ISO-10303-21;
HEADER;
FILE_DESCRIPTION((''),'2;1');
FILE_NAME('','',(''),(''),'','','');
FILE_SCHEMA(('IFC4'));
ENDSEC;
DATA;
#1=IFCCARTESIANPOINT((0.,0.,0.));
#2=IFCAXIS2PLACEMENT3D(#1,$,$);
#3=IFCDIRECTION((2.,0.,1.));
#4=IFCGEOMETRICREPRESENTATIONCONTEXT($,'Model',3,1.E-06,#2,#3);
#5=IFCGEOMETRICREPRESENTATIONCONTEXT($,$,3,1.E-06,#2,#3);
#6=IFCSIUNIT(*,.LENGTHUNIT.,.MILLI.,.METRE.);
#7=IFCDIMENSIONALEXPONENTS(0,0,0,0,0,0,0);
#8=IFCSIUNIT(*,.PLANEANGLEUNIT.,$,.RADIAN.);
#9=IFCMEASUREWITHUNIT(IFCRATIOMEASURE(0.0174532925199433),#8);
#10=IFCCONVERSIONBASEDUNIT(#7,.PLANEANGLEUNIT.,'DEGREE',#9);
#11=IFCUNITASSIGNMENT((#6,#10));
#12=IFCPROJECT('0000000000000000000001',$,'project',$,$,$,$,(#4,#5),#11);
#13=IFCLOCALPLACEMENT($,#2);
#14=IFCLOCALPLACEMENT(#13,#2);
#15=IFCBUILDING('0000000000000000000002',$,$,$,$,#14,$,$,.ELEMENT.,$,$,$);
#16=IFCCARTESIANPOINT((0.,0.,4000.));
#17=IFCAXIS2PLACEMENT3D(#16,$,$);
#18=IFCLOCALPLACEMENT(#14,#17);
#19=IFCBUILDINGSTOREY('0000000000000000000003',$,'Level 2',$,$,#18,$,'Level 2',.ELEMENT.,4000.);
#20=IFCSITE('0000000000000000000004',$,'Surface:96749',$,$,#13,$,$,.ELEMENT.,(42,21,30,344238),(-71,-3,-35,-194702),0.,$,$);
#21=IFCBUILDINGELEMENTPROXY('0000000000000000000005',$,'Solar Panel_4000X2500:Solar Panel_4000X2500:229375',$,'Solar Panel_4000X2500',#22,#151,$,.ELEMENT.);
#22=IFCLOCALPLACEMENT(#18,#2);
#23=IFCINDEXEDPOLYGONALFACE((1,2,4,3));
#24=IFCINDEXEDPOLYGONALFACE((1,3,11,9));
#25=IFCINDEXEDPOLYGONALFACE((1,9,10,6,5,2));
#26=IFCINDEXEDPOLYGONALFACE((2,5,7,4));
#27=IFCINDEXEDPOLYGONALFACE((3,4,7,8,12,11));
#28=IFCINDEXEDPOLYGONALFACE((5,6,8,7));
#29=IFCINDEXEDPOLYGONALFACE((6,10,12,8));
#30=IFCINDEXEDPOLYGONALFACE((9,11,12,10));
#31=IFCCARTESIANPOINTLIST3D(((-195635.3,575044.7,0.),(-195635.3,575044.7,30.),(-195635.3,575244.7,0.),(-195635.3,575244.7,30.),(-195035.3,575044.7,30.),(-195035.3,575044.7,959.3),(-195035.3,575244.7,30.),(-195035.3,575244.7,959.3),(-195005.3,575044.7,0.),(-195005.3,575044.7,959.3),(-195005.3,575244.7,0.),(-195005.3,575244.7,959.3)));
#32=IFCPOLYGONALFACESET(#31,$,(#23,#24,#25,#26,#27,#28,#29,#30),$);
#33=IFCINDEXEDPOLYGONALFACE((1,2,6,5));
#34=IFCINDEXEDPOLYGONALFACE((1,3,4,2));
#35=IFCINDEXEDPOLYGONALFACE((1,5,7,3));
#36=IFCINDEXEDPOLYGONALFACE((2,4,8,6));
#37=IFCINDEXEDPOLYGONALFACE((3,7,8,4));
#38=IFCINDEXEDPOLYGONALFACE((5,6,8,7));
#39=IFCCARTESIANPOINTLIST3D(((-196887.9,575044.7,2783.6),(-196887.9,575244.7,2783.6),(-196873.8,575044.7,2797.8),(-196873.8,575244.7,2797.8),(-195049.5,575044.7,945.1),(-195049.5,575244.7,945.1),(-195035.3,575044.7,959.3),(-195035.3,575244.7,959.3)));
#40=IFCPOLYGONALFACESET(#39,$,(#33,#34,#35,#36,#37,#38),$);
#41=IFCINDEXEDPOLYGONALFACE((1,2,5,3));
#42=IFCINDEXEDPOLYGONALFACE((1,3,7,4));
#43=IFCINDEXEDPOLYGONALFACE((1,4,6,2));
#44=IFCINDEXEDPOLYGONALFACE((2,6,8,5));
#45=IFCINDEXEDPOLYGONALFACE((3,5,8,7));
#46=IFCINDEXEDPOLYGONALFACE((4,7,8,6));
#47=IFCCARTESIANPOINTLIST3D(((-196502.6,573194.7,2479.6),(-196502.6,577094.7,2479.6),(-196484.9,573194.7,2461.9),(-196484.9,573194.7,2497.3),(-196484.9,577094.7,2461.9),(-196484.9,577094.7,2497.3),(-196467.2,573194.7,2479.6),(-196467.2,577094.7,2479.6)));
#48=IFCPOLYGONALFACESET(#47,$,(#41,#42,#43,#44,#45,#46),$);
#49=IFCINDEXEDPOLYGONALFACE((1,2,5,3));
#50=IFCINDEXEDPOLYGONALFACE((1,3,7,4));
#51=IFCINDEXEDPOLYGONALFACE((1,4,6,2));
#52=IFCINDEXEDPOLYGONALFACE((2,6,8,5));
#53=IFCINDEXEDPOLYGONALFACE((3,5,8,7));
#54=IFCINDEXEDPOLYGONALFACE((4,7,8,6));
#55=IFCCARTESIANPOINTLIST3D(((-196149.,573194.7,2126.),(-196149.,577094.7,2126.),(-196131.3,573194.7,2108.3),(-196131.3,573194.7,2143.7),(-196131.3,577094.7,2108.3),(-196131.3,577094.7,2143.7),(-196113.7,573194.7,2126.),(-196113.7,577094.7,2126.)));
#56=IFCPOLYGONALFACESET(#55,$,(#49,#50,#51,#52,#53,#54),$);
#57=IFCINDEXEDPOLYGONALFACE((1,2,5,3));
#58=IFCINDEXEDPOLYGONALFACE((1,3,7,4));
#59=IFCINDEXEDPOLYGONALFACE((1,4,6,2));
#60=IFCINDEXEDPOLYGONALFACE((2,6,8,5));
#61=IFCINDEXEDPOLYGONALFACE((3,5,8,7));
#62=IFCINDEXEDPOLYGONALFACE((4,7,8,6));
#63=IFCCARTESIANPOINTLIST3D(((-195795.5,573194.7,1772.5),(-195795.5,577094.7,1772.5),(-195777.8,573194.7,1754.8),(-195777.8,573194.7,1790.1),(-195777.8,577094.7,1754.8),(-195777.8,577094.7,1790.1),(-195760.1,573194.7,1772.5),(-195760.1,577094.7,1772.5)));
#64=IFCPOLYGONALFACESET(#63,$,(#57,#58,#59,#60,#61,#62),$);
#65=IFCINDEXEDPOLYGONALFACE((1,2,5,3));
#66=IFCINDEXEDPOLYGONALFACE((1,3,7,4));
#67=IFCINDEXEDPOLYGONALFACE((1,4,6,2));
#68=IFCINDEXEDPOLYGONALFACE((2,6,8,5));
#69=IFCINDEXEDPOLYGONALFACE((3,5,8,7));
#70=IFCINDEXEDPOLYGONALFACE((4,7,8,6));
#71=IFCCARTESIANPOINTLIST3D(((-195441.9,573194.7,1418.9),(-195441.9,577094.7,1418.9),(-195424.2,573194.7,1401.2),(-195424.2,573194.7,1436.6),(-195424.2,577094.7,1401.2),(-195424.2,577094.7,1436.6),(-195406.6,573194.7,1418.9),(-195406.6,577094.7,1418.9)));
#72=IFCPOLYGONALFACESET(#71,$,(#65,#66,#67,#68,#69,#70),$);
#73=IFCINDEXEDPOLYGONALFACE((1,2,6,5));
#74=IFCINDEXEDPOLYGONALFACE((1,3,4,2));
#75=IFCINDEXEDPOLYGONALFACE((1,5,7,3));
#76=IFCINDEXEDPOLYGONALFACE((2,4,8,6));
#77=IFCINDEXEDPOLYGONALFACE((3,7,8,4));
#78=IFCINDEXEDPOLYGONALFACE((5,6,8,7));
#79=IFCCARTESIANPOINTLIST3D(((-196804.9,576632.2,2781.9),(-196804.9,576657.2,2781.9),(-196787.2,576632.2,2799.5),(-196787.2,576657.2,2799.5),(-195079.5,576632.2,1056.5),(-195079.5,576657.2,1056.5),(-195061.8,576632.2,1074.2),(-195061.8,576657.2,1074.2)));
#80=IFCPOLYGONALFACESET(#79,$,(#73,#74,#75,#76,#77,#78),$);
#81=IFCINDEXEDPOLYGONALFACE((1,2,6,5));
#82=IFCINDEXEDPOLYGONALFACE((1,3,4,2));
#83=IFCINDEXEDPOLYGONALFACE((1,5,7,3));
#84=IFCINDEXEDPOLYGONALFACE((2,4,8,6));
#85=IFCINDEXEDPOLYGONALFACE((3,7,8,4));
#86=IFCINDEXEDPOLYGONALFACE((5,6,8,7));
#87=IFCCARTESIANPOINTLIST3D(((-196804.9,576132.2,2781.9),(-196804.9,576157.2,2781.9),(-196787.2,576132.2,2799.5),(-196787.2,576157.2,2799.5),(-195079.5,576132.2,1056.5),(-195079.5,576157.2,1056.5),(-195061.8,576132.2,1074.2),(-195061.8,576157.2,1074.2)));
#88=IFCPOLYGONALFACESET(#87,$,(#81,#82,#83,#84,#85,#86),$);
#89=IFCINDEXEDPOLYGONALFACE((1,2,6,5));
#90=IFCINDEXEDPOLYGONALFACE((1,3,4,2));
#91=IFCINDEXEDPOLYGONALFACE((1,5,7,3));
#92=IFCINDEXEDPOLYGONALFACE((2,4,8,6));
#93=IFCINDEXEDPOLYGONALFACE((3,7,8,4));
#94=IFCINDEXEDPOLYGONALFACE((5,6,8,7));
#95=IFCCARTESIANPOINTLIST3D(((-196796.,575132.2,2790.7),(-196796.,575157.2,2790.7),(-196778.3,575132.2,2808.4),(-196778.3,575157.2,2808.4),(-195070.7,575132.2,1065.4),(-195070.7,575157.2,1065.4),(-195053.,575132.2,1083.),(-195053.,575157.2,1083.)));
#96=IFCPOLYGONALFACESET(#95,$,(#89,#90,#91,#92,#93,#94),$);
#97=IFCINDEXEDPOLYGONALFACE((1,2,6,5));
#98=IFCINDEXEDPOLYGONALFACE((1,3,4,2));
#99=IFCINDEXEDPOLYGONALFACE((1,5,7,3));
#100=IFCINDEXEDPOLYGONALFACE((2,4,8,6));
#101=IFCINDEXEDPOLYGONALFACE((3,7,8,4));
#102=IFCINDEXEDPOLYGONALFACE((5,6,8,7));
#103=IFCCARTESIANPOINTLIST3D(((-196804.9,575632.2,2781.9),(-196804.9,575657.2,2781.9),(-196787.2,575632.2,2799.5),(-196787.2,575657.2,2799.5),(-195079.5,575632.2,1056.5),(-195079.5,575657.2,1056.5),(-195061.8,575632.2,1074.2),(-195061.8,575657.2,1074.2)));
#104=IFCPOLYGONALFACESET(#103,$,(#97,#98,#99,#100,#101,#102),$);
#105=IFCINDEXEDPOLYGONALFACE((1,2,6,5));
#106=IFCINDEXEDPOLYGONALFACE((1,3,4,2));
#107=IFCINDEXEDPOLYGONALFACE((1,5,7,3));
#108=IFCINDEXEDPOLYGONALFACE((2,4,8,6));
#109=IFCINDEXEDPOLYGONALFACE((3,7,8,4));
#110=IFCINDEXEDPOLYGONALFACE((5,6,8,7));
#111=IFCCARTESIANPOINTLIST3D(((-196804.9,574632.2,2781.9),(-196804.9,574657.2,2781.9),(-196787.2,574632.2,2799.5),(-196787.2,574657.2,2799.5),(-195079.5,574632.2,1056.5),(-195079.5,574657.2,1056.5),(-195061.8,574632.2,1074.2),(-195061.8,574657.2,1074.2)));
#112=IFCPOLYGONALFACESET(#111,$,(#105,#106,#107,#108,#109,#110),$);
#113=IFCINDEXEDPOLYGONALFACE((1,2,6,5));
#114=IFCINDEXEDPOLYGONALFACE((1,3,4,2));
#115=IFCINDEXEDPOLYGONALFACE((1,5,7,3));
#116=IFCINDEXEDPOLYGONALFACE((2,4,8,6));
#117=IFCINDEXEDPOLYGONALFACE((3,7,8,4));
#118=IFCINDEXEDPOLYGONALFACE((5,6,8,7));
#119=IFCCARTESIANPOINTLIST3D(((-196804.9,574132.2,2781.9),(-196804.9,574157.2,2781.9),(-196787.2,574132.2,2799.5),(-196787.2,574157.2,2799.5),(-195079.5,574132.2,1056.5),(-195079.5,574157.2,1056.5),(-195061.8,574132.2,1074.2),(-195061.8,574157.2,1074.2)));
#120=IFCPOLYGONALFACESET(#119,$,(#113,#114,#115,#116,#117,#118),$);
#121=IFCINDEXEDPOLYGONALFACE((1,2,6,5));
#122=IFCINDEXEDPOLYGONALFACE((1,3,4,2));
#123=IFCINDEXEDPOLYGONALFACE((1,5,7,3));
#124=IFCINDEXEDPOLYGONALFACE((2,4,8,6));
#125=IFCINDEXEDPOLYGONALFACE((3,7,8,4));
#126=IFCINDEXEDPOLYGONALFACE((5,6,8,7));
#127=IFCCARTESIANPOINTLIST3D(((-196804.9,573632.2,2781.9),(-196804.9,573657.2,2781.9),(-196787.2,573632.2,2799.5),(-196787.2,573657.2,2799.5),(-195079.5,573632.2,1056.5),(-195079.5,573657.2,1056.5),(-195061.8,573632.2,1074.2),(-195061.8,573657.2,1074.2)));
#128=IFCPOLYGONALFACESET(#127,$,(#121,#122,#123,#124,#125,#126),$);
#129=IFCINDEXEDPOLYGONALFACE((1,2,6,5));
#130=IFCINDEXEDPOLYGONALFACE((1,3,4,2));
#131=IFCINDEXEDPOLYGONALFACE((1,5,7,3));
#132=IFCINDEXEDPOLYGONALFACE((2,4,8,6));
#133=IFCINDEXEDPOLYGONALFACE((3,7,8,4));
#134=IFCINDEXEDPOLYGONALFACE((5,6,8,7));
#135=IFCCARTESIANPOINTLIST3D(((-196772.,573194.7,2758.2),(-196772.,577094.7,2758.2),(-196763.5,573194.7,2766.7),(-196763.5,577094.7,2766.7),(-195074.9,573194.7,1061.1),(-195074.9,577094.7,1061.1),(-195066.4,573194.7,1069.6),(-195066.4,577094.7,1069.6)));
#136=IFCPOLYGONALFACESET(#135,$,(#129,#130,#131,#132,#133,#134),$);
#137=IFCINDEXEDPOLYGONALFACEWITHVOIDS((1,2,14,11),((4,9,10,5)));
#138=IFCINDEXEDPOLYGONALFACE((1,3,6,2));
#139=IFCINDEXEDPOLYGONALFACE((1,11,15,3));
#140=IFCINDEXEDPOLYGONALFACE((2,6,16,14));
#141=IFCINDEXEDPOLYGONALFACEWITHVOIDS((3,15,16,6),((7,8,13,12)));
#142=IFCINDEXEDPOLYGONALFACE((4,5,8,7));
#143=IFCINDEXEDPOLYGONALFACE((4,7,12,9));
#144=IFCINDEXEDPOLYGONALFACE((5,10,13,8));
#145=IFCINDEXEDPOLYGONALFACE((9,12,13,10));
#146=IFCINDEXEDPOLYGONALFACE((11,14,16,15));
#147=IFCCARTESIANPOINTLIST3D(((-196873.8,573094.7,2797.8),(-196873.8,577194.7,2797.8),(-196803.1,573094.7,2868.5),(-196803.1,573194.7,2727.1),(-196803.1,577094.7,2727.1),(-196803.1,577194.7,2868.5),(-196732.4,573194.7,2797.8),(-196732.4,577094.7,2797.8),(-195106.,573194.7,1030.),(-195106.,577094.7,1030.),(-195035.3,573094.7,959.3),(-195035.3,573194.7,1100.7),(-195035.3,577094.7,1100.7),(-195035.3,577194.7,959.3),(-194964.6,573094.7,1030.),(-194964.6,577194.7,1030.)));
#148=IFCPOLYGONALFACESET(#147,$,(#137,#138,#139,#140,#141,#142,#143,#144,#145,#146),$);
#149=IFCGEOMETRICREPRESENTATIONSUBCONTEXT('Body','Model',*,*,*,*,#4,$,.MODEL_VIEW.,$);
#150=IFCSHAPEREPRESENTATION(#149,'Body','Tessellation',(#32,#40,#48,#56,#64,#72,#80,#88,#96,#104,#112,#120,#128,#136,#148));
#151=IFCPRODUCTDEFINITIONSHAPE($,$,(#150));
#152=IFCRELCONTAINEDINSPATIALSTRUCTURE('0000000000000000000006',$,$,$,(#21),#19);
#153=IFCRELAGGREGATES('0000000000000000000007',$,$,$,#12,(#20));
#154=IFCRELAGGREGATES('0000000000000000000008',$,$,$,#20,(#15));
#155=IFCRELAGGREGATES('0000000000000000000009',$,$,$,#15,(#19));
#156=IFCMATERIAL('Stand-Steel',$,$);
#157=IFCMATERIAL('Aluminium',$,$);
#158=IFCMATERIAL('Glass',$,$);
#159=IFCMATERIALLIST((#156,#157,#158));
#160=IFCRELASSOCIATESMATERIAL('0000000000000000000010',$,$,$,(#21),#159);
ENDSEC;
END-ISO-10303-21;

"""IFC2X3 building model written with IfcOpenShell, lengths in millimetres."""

from ifc_helpers import new_model, entity, si_unit, converted_unit, direction, frame, frame_2d, origin, origin_2d_with_axis, place, context, subcontext, project, spatial, polyline, rectangle, outline, extrude, source, transform, mapped, material, material_list, element, save


model = new_model("IFC2X3")

# Units and contexts
model_context = context("Model", 3, precision=1e-06, world=origin(), true_north=direction((2.0, 0.0, 1.0)))
context_of_model = context(None, 3, precision=1e-06, world=origin(), true_north=direction((2.0, 0.0, 1.0)))
body_context = subcontext(model_context, "Body", "Model", "MODEL_VIEW")
ifc_project = project(units=[si_unit("LENGTHUNIT", "METRE", prefix="MILLI"), converted_unit("PLANEANGLEUNIT", "DEGREE", entity("IfcRatioMeasure", 0.0174532925199433), si_unit("PLANEANGLEUNIT", "RADIAN"), dimensions=[0, 0, 0, 0, 0, 0, 0])], contexts=[model_context, context_of_model])

# Site, building, storey
site_placement = place(None, origin())
site = spatial("IfcSite", under=ifc_project, at=site_placement, Name="Surface:96749", CompositionType="ELEMENT", RefLatitude=(42, 21, 30, 344238), RefLongitude=(-71, -3, -35, -194702), RefElevation=0.0)
building_placement = place(site_placement, origin())
building = spatial("IfcBuilding", under=site, at=building_placement, CompositionType="ELEMENT")
storey_placement = place(building_placement, frame((0.0, 0.0, 4000.0)))
storey = spatial("IfcBuildingStorey", under=building, at=storey_placement, Name="Level 2", LongName="Level 2", CompositionType="ELEMENT", Elevation=4000.0)

# Building element proxy
ifc_material_1 = material(Name="Stand-Steel")
ifc_material_2 = material(Name="Aluminium")
ifc_material_3 = material(Name="Glass")
shared_shape = source(origin(), body_context, "Body", "SweptSolid", [
    extrude(outline(polyline([(-629.5, -220.0), (329.8, -220.0), (329.8, 410.0), (299.8, 410.0), (299.8, -190.0), (-629.5, -190.0), (-629.5, -220.0)])), frame((-190.0, -100.0, 299.8), z_axis=(0.0, 1.0, 0.0), x_axis=(0.0, 0.0, -1.0)), (0.0, 0.0, 1.0), 200.0),
    extrude(rectangle(XDim=20.0, YDim=200.0, at=frame_2d((0.0, 0.0), x_axis=(0.0, 1.0))), frame((-7.1, 0.0, 922.2), z_axis=(-0.707107, 0.0, 0.707107), x_axis=(0.0, 1.0, 0.0)), (0.0, 0.0, 1.0), 2600.0),
    extrude(rectangle(XDim=25.0, YDim=25.0, at=frame_2d((0.0, 0.0), x_axis=(1.0, 0.0))), frame((-1449.6, -1950.0, 2449.6), z_axis=(0.0, 1.0, 0.0), x_axis=(-0.707107, 0.0, -0.707107)), (0.0, 0.0, 1.0), 3900.0),
    extrude(rectangle(XDim=25.0, YDim=25.0, at=origin_2d_with_axis()), frame((-1096.0, -1950.0, 2096.0), z_axis=(0.0, 1.0, 0.0), x_axis=(-0.707107, 0.0, -0.707107)), (0.0, 0.0, 1.0), 3900.0),
    extrude(rectangle(XDim=25.0, YDim=25.0, at=origin_2d_with_axis()), frame((-742.5, -1950.0, 1742.5), z_axis=(0.0, 1.0, 0.0), x_axis=(-0.707107, 0.0, -0.707107)), (0.0, 0.0, 1.0), 3900.0),
    extrude(rectangle(XDim=25.0, YDim=25.0, at=frame_2d((0.0, 0.0), x_axis=(1.0, 0.0))), frame((-388.9, -1950.0, 1388.9), z_axis=(0.0, 1.0, 0.0), x_axis=(-0.707107, 0.0, -0.707107)), (0.0, 0.0, 1.0), 3900.0),
    extrude(rectangle(XDim=25.0, YDim=25.0, at=frame_2d((0.0, 0.0), x_axis=(0.0, 1.0))), frame((-35.4, 1500.0, 1035.4), z_axis=(-0.707107, 0.0, 0.707107), x_axis=(0.0, 1.0, 0.0)), (0.0, 0.0, 1.0), 2440.0),
    extrude(rectangle(XDim=25.0, YDim=25.0, at=frame_2d((0.0, 0.0), x_axis=(0.0, 1.0))), frame((-35.4, 1000.0, 1035.4), z_axis=(-0.707107, 0.0, 0.707107), x_axis=(0.0, 1.0, 0.0)), (0.0, 0.0, 1.0), 2440.0),
    extrude(rectangle(XDim=25.0, YDim=25.0, at=frame_2d((0.0, 0.0), x_axis=(0.0, 1.0))), frame((-26.5, 0.0, 1044.2), z_axis=(-0.707107, 0.0, 0.707107), x_axis=(0.0, -1.0, 0.0)), (0.0, 0.0, 1.0), 2440.0),
    extrude(rectangle(XDim=25.0, YDim=25.0, at=frame_2d((0.0, 0.0), x_axis=(0.0, 1.0))), frame((-35.4, 500.0, 1035.4), z_axis=(-0.707107, 0.0, 0.707107), x_axis=(0.0, 1.0, 0.0)), (0.0, 0.0, 1.0), 2440.0),
    extrude(rectangle(XDim=25.0, YDim=25.0, at=frame_2d((0.0, 0.0), x_axis=(0.0, 1.0))), frame((-35.4, -500.0, 1035.4), z_axis=(-0.707107, 0.0, 0.707107), x_axis=(0.0, 1.0, 0.0)), (0.0, 0.0, 1.0), 2440.0),
    extrude(rectangle(XDim=25.0, YDim=25.0, at=frame_2d((0.0, 0.0), x_axis=(0.0, 1.0))), frame((-35.4, -1000.0, 1035.4), z_axis=(-0.707107, 0.0, 0.707107), x_axis=(0.0, 1.0, 0.0)), (0.0, 0.0, 1.0), 2440.0),
    extrude(rectangle(XDim=25.0, YDim=25.0, at=frame_2d((0.0, 0.0), x_axis=(0.0, 1.0))), frame((-35.4, -1500.0, 1035.4), z_axis=(-0.707107, 0.0, 0.707107), x_axis=(0.0, 1.0, 0.0)), (0.0, 0.0, 1.0), 2440.0),
    extrude(rectangle(XDim=2400.0, YDim=12.0, at=frame_2d((0.0, 0.0), x_axis=(1.0, 0.0))), frame((-883.9, -1950.0, 1883.9), z_axis=(0.0, 1.0, 0.0), x_axis=(0.707107, 0.0, -0.707107)), (0.0, 0.0, 1.0), 3900.0),
    extrude(outline(polyline([(-2050.0, -1300.0), (2050.0, -1300.0), (2050.0, 1300.0), (-2050.0, 1300.0), (-2050.0, -1300.0)]), holes=[polyline([(1950.0, -1200.0), (-1950.0, -1200.0), (-1950.0, 1200.0), (1950.0, 1200.0), (1950.0, -1200.0)])]), frame((-919.2, 0.0, 1848.5), z_axis=(0.707107, 0.0, 0.707107), x_axis=(0.0, 1.0, 0.0)), (0.0, 0.0, 1.0), 100.0),
])
ifc_material_list_1 = material_list([ifc_material_1, ifc_material_2, ifc_material_3])
proxy_1_placement = place(storey_placement, frame((-195035.3, 575144.7, 30.0)))
element("IfcBuildingElementProxy", 1, at=proxy_1_placement, inside=storey, material=ifc_material_list_1, Name="Solar Panel_4000X2500:Solar Panel_4000X2500:229375", ObjectType="Solar Panel_4000X2500", CompositionType="ELEMENT", context=body_context, shape_type="MappedRepresentation", body=[
    mapped(shared_shape, transform((0.0, 0.0, 0.0), scale=1.0)),
])

save(model, "model.ifc")
